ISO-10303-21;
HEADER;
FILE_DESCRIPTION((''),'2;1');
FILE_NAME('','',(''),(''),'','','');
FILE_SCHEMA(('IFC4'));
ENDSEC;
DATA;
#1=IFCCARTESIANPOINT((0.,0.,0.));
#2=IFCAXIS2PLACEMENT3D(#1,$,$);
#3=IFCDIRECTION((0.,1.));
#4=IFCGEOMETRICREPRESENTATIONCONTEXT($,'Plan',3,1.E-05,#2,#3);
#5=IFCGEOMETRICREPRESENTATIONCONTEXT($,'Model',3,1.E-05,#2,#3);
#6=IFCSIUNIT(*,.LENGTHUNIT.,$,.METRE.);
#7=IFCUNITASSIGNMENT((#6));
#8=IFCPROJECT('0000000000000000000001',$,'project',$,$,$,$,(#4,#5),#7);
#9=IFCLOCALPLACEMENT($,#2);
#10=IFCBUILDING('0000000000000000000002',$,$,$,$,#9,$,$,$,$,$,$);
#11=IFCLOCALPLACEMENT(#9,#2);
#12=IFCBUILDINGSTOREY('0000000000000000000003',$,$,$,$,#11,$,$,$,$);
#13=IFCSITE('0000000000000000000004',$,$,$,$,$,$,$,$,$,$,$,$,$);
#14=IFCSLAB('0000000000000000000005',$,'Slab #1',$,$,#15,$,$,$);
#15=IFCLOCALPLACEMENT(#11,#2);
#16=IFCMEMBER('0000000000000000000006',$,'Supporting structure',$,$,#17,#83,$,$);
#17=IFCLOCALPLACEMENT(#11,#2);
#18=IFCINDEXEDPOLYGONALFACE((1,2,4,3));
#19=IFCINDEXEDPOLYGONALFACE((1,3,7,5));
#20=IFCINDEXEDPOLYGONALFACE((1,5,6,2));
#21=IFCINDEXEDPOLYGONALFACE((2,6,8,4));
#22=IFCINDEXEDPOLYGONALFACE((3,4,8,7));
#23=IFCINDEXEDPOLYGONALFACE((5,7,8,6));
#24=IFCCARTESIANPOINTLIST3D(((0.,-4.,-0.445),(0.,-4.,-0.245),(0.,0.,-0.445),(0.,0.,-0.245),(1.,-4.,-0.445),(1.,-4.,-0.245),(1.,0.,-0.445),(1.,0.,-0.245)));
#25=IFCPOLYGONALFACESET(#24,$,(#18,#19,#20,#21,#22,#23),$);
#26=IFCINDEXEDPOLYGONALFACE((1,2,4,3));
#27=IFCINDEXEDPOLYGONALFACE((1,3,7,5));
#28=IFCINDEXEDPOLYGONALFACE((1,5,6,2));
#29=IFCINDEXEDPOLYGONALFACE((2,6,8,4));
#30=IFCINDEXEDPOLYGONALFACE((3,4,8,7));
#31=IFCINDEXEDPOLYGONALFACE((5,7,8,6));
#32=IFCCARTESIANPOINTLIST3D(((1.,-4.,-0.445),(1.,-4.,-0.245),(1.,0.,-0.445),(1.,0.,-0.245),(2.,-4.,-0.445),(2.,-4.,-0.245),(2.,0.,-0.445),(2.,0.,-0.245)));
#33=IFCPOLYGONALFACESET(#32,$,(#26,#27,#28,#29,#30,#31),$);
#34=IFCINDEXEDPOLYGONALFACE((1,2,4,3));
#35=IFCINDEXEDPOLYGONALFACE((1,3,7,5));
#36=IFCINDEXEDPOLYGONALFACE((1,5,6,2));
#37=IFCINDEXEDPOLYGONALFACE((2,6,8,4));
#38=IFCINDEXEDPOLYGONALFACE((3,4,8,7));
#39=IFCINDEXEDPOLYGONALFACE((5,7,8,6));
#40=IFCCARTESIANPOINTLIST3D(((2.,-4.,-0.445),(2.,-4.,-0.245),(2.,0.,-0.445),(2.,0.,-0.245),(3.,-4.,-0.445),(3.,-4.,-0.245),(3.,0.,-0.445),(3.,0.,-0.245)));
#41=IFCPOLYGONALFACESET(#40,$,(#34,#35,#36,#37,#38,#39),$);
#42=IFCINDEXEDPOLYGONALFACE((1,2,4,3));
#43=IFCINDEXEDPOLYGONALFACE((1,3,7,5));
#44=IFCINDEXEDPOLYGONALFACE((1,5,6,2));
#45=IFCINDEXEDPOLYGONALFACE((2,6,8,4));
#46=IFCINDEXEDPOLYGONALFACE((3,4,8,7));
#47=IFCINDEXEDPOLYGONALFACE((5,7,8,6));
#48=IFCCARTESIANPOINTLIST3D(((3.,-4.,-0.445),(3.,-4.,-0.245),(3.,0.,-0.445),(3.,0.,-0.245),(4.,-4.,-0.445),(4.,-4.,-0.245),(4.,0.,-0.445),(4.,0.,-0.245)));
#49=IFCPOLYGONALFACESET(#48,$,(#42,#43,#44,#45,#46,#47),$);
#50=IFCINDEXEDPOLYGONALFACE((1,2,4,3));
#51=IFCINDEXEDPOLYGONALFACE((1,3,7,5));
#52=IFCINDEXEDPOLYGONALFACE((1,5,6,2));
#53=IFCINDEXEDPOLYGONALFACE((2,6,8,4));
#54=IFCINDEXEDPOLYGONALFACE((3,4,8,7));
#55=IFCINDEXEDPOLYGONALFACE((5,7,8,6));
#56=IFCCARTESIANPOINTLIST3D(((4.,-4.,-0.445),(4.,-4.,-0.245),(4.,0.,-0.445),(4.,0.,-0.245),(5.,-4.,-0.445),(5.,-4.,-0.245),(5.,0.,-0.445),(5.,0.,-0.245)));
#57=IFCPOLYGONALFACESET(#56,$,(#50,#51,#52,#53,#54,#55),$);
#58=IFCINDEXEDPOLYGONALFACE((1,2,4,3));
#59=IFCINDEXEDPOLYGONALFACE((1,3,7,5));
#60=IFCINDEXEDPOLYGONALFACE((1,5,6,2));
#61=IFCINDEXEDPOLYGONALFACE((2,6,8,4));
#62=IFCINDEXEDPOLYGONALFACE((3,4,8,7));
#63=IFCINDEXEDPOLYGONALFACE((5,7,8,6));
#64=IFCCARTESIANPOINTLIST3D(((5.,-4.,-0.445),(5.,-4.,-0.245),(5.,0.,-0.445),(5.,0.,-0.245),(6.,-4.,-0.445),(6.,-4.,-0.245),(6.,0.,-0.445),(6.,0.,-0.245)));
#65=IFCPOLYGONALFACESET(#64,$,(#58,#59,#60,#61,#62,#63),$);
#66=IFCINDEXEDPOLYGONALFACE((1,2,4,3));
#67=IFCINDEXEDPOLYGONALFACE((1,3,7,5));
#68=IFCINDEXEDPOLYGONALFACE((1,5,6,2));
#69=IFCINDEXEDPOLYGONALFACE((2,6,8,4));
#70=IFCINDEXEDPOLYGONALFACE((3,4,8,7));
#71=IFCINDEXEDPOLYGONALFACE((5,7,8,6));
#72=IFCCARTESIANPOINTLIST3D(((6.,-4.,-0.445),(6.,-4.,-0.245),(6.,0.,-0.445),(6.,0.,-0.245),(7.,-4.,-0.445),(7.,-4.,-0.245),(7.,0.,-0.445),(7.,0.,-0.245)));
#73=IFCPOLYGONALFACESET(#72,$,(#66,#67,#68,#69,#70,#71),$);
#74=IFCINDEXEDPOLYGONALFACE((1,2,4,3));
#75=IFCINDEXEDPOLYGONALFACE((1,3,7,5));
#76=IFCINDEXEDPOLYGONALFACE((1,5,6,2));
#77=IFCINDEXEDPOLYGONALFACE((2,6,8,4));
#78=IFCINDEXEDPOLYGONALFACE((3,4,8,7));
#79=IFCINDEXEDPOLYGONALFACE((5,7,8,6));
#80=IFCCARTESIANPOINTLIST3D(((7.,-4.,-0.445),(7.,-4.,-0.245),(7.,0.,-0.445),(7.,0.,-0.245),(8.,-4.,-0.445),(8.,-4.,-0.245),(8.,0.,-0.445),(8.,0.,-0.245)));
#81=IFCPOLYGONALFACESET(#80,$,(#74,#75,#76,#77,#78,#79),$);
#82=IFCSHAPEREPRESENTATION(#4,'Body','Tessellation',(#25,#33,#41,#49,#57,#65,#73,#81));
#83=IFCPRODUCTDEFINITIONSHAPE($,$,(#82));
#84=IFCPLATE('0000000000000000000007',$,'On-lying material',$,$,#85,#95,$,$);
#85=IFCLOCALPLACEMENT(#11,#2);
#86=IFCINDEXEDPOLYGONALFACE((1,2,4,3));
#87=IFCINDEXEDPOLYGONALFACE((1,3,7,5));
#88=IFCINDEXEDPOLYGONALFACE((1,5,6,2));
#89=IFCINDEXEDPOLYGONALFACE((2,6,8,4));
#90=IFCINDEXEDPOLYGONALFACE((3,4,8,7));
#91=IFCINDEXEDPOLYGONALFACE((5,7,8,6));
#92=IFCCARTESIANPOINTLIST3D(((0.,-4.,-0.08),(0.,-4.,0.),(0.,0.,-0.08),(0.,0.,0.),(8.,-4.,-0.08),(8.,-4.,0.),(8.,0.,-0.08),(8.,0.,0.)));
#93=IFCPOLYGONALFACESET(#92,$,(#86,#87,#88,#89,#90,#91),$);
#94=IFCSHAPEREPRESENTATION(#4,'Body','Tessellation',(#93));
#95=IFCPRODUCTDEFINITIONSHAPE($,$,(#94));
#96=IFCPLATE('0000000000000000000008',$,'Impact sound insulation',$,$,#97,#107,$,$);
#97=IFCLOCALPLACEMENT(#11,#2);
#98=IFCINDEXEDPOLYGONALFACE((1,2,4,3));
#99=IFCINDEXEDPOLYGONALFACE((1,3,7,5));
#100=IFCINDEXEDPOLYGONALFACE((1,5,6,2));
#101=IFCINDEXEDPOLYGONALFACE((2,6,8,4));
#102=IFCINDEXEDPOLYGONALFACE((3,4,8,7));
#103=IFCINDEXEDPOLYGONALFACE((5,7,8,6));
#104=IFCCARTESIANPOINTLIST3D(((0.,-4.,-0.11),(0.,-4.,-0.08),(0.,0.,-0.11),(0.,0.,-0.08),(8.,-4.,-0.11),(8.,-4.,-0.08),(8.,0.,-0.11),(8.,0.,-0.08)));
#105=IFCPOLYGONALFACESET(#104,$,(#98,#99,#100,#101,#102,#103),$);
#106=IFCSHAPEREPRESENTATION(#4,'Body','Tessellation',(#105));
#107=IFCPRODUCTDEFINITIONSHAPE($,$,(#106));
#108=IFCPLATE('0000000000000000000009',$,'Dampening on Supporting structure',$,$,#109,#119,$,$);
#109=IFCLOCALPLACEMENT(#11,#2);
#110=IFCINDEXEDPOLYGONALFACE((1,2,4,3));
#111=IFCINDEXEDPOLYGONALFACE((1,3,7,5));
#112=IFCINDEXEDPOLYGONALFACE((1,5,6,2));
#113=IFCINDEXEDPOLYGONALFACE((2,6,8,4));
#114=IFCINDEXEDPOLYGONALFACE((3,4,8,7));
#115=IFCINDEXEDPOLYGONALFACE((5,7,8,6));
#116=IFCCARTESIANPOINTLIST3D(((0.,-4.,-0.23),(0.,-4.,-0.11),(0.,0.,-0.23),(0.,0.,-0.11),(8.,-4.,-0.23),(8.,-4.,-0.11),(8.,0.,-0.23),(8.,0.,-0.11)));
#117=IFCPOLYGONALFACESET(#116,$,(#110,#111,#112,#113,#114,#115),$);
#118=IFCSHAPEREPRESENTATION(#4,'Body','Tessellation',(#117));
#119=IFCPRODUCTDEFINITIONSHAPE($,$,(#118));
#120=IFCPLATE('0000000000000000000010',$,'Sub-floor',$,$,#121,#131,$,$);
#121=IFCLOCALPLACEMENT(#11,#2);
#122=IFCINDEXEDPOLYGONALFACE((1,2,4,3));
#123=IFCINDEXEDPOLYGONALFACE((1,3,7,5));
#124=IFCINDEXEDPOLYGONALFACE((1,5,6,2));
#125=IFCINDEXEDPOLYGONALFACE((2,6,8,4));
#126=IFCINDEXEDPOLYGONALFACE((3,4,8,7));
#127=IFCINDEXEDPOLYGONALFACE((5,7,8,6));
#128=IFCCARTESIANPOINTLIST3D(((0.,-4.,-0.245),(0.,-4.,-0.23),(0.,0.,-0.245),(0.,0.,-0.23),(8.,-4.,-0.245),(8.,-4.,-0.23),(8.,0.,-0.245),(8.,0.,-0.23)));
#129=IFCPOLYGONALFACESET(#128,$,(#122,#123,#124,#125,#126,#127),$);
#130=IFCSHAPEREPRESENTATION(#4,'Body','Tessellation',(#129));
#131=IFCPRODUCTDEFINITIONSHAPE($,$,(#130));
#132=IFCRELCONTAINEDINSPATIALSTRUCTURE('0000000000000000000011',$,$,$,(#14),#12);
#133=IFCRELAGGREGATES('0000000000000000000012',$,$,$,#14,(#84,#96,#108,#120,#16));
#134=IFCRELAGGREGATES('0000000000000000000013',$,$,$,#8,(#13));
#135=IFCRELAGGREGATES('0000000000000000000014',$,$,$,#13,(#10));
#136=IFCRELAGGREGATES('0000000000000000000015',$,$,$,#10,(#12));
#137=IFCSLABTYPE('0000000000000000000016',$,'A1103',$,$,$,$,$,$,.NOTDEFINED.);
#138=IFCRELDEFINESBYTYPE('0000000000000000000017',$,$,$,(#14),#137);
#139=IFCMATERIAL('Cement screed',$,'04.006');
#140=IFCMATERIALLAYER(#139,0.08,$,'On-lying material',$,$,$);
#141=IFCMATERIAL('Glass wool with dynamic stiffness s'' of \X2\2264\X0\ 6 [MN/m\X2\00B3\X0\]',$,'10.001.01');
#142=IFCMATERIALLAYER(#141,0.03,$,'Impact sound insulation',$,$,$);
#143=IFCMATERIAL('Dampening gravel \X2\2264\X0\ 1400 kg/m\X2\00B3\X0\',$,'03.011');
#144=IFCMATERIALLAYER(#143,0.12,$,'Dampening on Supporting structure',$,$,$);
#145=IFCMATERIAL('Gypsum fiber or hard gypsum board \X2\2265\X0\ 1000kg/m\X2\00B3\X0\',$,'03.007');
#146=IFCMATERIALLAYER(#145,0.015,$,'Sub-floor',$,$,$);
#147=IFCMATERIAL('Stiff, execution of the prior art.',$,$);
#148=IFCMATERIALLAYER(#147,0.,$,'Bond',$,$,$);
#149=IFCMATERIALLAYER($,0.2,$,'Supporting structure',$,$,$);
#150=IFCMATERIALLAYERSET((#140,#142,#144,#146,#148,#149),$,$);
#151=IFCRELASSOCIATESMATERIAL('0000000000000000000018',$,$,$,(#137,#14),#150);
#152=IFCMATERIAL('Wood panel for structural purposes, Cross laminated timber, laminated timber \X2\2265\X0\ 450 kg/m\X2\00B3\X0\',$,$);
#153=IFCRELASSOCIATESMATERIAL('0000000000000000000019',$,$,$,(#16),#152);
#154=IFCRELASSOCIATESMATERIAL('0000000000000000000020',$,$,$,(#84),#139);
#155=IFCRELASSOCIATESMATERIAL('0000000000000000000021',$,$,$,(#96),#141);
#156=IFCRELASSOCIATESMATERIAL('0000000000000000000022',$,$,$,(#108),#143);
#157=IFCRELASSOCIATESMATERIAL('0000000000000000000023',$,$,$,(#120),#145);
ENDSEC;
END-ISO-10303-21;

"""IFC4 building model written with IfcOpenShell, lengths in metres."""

from ifc_helpers import new_model, si_unit, direction, frame, frame_2d, origin, origin_with_axes, place, context, project, spatial, rectangle, extrude, material, layer, layer_set, type_object, element, aggregate, save


model = new_model("IFC4")

# Units and contexts
plan_context = context("Plan", 3, precision=1e-05, world=origin(), true_north=direction((0.0, 1.0)))
model_context = context("Model", 3, precision=1e-05, world=origin(), true_north=direction((0.0, 1.0)))
ifc_project = project(units=[si_unit("LENGTHUNIT", "METRE")], contexts=[plan_context, model_context])

# Site, building, storey
site = spatial("IfcSite", under=ifc_project)
building_placement = place(None, origin())
building = spatial("IfcBuilding", under=site, at=building_placement)
storey_placement = place(building_placement, origin())
storey = spatial("IfcBuildingStorey", under=building, at=storey_placement)

# Slab, member, plates
ifc_material_1 = material(Name="Cement screed", Category="04.006")
ifc_layer_1 = layer(ifc_material_1, 0.08, Name="On-lying material")
ifc_material_2 = material(Name="Glass wool with dynamic stiffness s' of ≤ 6 [MN/m³]", Category="10.001.01")
ifc_layer_2 = layer(ifc_material_2, 0.03, Name="Impact sound insulation")
ifc_material_3 = material(Name="Dampening gravel ≤ 1400 kg/m³", Category="03.011")
ifc_layer_3 = layer(ifc_material_3, 0.12, Name="Dampening on Supporting structure")
ifc_material_4 = material(Name="Gypsum fiber or hard gypsum board ≥ 1000kg/m³", Category="03.007")
ifc_layer_4 = layer(ifc_material_4, 0.015, Name="Sub-floor")
ifc_material_5 = material(Name="Stiff, execution of the prior art.")
ifc_layer_5 = layer(ifc_material_5, 0.0, Name="Bond")
ifc_layer_6 = layer(None, 0.2, Name="Supporting structure")
ifc_layer_set = layer_set([ifc_layer_1, ifc_layer_2, ifc_layer_3, ifc_layer_4, ifc_layer_5, ifc_layer_6])
slab_type = type_object("IfcSlabType", Name="A1103", PredefinedType="NOTDEFINED", material=ifc_layer_set)
slab_placement = place(None, frame((0.0, 0.0, 0.0), z_axis=(0.0, 0.0, -1.0), x_axis=(1.0, 0.0, 0.0)))
slab = element("IfcSlab", 1, at=slab_placement, inside=storey, type_object=slab_type, material=ifc_layer_set, Name="Slab #1")
ifc_material_6 = material(Name="Wood panel for structural purposes, Cross laminated timber, laminated timber ≥ 450 kg/m³")
member_placement = place(slab_placement, origin())
member = element("IfcMember", 2, at=member_placement, material=ifc_material_6, Name="Supporting structure", context=plan_context, shape_type="SweptSolid", body=[
    extrude(rectangle(XDim=1.0, YDim=0.2, at=frame_2d((0.5, 0.1), x_axis=(1.0, 0.0))), frame((0.0, 4.0, 0.245), z_axis=(0.0, -1.0, 0.0), x_axis=(1.0, 0.0, 0.0)), (0.0, 0.0, 1.0), 4.0),
    extrude(rectangle(XDim=1.0, YDim=0.2, at=frame_2d((0.5, 0.1), x_axis=(1.0, 0.0))), frame((1.0, 4.0, 0.245), z_axis=(0.0, -1.0, 0.0), x_axis=(1.0, 0.0, 0.0)), (0.0, 0.0, 1.0), 4.0),
    extrude(rectangle(XDim=1.0, YDim=0.2, at=frame_2d((0.5, 0.1), x_axis=(1.0, 0.0))), frame((2.0, 4.0, 0.245), z_axis=(0.0, -1.0, 0.0), x_axis=(1.0, 0.0, 0.0)), (0.0, 0.0, 1.0), 4.0),
    extrude(rectangle(XDim=1.0, YDim=0.2, at=frame_2d((0.5, 0.1), x_axis=(1.0, 0.0))), frame((3.0, 4.0, 0.245), z_axis=(0.0, -1.0, 0.0), x_axis=(1.0, 0.0, 0.0)), (0.0, 0.0, 1.0), 4.0),
    extrude(rectangle(XDim=1.0, YDim=0.2, at=frame_2d((0.5, 0.1), x_axis=(1.0, 0.0))), frame((4.0, 4.0, 0.245), z_axis=(0.0, -1.0, 0.0), x_axis=(1.0, 0.0, 0.0)), (0.0, 0.0, 1.0), 4.0),
    extrude(rectangle(XDim=1.0, YDim=0.2, at=frame_2d((0.5, 0.1), x_axis=(1.0, 0.0))), frame((5.0, 4.0, 0.245), z_axis=(0.0, -1.0, 0.0), x_axis=(1.0, 0.0, 0.0)), (0.0, 0.0, 1.0), 4.0),
    extrude(rectangle(XDim=1.0, YDim=0.2, at=frame_2d((0.5, 0.1), x_axis=(1.0, 0.0))), frame((6.0, 4.0, 0.245), z_axis=(0.0, -1.0, 0.0), x_axis=(1.0, 0.0, 0.0)), (0.0, 0.0, 1.0), 4.0),
    extrude(rectangle(XDim=1.0, YDim=0.2, at=frame_2d((0.5, 0.1), x_axis=(1.0, 0.0))), frame((7.0, 4.0, 0.245), z_axis=(0.0, -1.0, 0.0), x_axis=(1.0, 0.0, 0.0)), (0.0, 0.0, 1.0), 4.0),
])
plate_1_placement = place(slab_placement, origin())
plate_1 = element("IfcPlate", 3, at=plate_1_placement, material=ifc_material_1, Name="On-lying material", context=plan_context, shape_type="SweptSolid", body=[
    extrude(rectangle(XDim=8.0, YDim=4.0, at=frame_2d((4.0, 2.0), x_axis=(1.0, 0.0))), origin_with_axes(), (0.0, 0.0, 1.0), 0.08),
])
plate_2_placement = place(slab_placement, origin())
plate_2 = element("IfcPlate", 4, at=plate_2_placement, material=ifc_material_2, Name="Impact sound insulation", context=plan_context, shape_type="SweptSolid", body=[
    extrude(rectangle(XDim=8.0, YDim=4.0, at=frame_2d((4.0, 2.0), x_axis=(1.0, 0.0))), frame((0.0, 0.0, 0.08), z_axis=(0.0, 0.0, 1.0), x_axis=(1.0, 0.0, 0.0)), (0.0, 0.0, 1.0), 0.03),
])
plate_3_placement = place(slab_placement, origin())
plate_3 = element("IfcPlate", 5, at=plate_3_placement, material=ifc_material_3, Name="Dampening on Supporting structure", context=plan_context, shape_type="SweptSolid", body=[
    extrude(rectangle(XDim=8.0, YDim=4.0, at=frame_2d((4.0, 2.0), x_axis=(1.0, 0.0))), frame((0.0, 0.0, 0.11), z_axis=(0.0, 0.0, 1.0), x_axis=(1.0, 0.0, 0.0)), (0.0, 0.0, 1.0), 0.12),
])
plate_4_placement = place(slab_placement, origin())
plate_4 = element("IfcPlate", 6, at=plate_4_placement, material=ifc_material_4, Name="Sub-floor", context=plan_context, shape_type="SweptSolid", body=[
    extrude(rectangle(XDim=8.0, YDim=4.0, at=frame_2d((4.0, 2.0), x_axis=(1.0, 0.0))), frame((0.0, 0.0, 0.23), z_axis=(0.0, 0.0, 1.0), x_axis=(1.0, 0.0, 0.0)), (0.0, 0.0, 1.0), 0.015),
])
aggregate(slab, [plate_1, plate_2, plate_3, plate_4, member])

save(model, "model.ifc")
